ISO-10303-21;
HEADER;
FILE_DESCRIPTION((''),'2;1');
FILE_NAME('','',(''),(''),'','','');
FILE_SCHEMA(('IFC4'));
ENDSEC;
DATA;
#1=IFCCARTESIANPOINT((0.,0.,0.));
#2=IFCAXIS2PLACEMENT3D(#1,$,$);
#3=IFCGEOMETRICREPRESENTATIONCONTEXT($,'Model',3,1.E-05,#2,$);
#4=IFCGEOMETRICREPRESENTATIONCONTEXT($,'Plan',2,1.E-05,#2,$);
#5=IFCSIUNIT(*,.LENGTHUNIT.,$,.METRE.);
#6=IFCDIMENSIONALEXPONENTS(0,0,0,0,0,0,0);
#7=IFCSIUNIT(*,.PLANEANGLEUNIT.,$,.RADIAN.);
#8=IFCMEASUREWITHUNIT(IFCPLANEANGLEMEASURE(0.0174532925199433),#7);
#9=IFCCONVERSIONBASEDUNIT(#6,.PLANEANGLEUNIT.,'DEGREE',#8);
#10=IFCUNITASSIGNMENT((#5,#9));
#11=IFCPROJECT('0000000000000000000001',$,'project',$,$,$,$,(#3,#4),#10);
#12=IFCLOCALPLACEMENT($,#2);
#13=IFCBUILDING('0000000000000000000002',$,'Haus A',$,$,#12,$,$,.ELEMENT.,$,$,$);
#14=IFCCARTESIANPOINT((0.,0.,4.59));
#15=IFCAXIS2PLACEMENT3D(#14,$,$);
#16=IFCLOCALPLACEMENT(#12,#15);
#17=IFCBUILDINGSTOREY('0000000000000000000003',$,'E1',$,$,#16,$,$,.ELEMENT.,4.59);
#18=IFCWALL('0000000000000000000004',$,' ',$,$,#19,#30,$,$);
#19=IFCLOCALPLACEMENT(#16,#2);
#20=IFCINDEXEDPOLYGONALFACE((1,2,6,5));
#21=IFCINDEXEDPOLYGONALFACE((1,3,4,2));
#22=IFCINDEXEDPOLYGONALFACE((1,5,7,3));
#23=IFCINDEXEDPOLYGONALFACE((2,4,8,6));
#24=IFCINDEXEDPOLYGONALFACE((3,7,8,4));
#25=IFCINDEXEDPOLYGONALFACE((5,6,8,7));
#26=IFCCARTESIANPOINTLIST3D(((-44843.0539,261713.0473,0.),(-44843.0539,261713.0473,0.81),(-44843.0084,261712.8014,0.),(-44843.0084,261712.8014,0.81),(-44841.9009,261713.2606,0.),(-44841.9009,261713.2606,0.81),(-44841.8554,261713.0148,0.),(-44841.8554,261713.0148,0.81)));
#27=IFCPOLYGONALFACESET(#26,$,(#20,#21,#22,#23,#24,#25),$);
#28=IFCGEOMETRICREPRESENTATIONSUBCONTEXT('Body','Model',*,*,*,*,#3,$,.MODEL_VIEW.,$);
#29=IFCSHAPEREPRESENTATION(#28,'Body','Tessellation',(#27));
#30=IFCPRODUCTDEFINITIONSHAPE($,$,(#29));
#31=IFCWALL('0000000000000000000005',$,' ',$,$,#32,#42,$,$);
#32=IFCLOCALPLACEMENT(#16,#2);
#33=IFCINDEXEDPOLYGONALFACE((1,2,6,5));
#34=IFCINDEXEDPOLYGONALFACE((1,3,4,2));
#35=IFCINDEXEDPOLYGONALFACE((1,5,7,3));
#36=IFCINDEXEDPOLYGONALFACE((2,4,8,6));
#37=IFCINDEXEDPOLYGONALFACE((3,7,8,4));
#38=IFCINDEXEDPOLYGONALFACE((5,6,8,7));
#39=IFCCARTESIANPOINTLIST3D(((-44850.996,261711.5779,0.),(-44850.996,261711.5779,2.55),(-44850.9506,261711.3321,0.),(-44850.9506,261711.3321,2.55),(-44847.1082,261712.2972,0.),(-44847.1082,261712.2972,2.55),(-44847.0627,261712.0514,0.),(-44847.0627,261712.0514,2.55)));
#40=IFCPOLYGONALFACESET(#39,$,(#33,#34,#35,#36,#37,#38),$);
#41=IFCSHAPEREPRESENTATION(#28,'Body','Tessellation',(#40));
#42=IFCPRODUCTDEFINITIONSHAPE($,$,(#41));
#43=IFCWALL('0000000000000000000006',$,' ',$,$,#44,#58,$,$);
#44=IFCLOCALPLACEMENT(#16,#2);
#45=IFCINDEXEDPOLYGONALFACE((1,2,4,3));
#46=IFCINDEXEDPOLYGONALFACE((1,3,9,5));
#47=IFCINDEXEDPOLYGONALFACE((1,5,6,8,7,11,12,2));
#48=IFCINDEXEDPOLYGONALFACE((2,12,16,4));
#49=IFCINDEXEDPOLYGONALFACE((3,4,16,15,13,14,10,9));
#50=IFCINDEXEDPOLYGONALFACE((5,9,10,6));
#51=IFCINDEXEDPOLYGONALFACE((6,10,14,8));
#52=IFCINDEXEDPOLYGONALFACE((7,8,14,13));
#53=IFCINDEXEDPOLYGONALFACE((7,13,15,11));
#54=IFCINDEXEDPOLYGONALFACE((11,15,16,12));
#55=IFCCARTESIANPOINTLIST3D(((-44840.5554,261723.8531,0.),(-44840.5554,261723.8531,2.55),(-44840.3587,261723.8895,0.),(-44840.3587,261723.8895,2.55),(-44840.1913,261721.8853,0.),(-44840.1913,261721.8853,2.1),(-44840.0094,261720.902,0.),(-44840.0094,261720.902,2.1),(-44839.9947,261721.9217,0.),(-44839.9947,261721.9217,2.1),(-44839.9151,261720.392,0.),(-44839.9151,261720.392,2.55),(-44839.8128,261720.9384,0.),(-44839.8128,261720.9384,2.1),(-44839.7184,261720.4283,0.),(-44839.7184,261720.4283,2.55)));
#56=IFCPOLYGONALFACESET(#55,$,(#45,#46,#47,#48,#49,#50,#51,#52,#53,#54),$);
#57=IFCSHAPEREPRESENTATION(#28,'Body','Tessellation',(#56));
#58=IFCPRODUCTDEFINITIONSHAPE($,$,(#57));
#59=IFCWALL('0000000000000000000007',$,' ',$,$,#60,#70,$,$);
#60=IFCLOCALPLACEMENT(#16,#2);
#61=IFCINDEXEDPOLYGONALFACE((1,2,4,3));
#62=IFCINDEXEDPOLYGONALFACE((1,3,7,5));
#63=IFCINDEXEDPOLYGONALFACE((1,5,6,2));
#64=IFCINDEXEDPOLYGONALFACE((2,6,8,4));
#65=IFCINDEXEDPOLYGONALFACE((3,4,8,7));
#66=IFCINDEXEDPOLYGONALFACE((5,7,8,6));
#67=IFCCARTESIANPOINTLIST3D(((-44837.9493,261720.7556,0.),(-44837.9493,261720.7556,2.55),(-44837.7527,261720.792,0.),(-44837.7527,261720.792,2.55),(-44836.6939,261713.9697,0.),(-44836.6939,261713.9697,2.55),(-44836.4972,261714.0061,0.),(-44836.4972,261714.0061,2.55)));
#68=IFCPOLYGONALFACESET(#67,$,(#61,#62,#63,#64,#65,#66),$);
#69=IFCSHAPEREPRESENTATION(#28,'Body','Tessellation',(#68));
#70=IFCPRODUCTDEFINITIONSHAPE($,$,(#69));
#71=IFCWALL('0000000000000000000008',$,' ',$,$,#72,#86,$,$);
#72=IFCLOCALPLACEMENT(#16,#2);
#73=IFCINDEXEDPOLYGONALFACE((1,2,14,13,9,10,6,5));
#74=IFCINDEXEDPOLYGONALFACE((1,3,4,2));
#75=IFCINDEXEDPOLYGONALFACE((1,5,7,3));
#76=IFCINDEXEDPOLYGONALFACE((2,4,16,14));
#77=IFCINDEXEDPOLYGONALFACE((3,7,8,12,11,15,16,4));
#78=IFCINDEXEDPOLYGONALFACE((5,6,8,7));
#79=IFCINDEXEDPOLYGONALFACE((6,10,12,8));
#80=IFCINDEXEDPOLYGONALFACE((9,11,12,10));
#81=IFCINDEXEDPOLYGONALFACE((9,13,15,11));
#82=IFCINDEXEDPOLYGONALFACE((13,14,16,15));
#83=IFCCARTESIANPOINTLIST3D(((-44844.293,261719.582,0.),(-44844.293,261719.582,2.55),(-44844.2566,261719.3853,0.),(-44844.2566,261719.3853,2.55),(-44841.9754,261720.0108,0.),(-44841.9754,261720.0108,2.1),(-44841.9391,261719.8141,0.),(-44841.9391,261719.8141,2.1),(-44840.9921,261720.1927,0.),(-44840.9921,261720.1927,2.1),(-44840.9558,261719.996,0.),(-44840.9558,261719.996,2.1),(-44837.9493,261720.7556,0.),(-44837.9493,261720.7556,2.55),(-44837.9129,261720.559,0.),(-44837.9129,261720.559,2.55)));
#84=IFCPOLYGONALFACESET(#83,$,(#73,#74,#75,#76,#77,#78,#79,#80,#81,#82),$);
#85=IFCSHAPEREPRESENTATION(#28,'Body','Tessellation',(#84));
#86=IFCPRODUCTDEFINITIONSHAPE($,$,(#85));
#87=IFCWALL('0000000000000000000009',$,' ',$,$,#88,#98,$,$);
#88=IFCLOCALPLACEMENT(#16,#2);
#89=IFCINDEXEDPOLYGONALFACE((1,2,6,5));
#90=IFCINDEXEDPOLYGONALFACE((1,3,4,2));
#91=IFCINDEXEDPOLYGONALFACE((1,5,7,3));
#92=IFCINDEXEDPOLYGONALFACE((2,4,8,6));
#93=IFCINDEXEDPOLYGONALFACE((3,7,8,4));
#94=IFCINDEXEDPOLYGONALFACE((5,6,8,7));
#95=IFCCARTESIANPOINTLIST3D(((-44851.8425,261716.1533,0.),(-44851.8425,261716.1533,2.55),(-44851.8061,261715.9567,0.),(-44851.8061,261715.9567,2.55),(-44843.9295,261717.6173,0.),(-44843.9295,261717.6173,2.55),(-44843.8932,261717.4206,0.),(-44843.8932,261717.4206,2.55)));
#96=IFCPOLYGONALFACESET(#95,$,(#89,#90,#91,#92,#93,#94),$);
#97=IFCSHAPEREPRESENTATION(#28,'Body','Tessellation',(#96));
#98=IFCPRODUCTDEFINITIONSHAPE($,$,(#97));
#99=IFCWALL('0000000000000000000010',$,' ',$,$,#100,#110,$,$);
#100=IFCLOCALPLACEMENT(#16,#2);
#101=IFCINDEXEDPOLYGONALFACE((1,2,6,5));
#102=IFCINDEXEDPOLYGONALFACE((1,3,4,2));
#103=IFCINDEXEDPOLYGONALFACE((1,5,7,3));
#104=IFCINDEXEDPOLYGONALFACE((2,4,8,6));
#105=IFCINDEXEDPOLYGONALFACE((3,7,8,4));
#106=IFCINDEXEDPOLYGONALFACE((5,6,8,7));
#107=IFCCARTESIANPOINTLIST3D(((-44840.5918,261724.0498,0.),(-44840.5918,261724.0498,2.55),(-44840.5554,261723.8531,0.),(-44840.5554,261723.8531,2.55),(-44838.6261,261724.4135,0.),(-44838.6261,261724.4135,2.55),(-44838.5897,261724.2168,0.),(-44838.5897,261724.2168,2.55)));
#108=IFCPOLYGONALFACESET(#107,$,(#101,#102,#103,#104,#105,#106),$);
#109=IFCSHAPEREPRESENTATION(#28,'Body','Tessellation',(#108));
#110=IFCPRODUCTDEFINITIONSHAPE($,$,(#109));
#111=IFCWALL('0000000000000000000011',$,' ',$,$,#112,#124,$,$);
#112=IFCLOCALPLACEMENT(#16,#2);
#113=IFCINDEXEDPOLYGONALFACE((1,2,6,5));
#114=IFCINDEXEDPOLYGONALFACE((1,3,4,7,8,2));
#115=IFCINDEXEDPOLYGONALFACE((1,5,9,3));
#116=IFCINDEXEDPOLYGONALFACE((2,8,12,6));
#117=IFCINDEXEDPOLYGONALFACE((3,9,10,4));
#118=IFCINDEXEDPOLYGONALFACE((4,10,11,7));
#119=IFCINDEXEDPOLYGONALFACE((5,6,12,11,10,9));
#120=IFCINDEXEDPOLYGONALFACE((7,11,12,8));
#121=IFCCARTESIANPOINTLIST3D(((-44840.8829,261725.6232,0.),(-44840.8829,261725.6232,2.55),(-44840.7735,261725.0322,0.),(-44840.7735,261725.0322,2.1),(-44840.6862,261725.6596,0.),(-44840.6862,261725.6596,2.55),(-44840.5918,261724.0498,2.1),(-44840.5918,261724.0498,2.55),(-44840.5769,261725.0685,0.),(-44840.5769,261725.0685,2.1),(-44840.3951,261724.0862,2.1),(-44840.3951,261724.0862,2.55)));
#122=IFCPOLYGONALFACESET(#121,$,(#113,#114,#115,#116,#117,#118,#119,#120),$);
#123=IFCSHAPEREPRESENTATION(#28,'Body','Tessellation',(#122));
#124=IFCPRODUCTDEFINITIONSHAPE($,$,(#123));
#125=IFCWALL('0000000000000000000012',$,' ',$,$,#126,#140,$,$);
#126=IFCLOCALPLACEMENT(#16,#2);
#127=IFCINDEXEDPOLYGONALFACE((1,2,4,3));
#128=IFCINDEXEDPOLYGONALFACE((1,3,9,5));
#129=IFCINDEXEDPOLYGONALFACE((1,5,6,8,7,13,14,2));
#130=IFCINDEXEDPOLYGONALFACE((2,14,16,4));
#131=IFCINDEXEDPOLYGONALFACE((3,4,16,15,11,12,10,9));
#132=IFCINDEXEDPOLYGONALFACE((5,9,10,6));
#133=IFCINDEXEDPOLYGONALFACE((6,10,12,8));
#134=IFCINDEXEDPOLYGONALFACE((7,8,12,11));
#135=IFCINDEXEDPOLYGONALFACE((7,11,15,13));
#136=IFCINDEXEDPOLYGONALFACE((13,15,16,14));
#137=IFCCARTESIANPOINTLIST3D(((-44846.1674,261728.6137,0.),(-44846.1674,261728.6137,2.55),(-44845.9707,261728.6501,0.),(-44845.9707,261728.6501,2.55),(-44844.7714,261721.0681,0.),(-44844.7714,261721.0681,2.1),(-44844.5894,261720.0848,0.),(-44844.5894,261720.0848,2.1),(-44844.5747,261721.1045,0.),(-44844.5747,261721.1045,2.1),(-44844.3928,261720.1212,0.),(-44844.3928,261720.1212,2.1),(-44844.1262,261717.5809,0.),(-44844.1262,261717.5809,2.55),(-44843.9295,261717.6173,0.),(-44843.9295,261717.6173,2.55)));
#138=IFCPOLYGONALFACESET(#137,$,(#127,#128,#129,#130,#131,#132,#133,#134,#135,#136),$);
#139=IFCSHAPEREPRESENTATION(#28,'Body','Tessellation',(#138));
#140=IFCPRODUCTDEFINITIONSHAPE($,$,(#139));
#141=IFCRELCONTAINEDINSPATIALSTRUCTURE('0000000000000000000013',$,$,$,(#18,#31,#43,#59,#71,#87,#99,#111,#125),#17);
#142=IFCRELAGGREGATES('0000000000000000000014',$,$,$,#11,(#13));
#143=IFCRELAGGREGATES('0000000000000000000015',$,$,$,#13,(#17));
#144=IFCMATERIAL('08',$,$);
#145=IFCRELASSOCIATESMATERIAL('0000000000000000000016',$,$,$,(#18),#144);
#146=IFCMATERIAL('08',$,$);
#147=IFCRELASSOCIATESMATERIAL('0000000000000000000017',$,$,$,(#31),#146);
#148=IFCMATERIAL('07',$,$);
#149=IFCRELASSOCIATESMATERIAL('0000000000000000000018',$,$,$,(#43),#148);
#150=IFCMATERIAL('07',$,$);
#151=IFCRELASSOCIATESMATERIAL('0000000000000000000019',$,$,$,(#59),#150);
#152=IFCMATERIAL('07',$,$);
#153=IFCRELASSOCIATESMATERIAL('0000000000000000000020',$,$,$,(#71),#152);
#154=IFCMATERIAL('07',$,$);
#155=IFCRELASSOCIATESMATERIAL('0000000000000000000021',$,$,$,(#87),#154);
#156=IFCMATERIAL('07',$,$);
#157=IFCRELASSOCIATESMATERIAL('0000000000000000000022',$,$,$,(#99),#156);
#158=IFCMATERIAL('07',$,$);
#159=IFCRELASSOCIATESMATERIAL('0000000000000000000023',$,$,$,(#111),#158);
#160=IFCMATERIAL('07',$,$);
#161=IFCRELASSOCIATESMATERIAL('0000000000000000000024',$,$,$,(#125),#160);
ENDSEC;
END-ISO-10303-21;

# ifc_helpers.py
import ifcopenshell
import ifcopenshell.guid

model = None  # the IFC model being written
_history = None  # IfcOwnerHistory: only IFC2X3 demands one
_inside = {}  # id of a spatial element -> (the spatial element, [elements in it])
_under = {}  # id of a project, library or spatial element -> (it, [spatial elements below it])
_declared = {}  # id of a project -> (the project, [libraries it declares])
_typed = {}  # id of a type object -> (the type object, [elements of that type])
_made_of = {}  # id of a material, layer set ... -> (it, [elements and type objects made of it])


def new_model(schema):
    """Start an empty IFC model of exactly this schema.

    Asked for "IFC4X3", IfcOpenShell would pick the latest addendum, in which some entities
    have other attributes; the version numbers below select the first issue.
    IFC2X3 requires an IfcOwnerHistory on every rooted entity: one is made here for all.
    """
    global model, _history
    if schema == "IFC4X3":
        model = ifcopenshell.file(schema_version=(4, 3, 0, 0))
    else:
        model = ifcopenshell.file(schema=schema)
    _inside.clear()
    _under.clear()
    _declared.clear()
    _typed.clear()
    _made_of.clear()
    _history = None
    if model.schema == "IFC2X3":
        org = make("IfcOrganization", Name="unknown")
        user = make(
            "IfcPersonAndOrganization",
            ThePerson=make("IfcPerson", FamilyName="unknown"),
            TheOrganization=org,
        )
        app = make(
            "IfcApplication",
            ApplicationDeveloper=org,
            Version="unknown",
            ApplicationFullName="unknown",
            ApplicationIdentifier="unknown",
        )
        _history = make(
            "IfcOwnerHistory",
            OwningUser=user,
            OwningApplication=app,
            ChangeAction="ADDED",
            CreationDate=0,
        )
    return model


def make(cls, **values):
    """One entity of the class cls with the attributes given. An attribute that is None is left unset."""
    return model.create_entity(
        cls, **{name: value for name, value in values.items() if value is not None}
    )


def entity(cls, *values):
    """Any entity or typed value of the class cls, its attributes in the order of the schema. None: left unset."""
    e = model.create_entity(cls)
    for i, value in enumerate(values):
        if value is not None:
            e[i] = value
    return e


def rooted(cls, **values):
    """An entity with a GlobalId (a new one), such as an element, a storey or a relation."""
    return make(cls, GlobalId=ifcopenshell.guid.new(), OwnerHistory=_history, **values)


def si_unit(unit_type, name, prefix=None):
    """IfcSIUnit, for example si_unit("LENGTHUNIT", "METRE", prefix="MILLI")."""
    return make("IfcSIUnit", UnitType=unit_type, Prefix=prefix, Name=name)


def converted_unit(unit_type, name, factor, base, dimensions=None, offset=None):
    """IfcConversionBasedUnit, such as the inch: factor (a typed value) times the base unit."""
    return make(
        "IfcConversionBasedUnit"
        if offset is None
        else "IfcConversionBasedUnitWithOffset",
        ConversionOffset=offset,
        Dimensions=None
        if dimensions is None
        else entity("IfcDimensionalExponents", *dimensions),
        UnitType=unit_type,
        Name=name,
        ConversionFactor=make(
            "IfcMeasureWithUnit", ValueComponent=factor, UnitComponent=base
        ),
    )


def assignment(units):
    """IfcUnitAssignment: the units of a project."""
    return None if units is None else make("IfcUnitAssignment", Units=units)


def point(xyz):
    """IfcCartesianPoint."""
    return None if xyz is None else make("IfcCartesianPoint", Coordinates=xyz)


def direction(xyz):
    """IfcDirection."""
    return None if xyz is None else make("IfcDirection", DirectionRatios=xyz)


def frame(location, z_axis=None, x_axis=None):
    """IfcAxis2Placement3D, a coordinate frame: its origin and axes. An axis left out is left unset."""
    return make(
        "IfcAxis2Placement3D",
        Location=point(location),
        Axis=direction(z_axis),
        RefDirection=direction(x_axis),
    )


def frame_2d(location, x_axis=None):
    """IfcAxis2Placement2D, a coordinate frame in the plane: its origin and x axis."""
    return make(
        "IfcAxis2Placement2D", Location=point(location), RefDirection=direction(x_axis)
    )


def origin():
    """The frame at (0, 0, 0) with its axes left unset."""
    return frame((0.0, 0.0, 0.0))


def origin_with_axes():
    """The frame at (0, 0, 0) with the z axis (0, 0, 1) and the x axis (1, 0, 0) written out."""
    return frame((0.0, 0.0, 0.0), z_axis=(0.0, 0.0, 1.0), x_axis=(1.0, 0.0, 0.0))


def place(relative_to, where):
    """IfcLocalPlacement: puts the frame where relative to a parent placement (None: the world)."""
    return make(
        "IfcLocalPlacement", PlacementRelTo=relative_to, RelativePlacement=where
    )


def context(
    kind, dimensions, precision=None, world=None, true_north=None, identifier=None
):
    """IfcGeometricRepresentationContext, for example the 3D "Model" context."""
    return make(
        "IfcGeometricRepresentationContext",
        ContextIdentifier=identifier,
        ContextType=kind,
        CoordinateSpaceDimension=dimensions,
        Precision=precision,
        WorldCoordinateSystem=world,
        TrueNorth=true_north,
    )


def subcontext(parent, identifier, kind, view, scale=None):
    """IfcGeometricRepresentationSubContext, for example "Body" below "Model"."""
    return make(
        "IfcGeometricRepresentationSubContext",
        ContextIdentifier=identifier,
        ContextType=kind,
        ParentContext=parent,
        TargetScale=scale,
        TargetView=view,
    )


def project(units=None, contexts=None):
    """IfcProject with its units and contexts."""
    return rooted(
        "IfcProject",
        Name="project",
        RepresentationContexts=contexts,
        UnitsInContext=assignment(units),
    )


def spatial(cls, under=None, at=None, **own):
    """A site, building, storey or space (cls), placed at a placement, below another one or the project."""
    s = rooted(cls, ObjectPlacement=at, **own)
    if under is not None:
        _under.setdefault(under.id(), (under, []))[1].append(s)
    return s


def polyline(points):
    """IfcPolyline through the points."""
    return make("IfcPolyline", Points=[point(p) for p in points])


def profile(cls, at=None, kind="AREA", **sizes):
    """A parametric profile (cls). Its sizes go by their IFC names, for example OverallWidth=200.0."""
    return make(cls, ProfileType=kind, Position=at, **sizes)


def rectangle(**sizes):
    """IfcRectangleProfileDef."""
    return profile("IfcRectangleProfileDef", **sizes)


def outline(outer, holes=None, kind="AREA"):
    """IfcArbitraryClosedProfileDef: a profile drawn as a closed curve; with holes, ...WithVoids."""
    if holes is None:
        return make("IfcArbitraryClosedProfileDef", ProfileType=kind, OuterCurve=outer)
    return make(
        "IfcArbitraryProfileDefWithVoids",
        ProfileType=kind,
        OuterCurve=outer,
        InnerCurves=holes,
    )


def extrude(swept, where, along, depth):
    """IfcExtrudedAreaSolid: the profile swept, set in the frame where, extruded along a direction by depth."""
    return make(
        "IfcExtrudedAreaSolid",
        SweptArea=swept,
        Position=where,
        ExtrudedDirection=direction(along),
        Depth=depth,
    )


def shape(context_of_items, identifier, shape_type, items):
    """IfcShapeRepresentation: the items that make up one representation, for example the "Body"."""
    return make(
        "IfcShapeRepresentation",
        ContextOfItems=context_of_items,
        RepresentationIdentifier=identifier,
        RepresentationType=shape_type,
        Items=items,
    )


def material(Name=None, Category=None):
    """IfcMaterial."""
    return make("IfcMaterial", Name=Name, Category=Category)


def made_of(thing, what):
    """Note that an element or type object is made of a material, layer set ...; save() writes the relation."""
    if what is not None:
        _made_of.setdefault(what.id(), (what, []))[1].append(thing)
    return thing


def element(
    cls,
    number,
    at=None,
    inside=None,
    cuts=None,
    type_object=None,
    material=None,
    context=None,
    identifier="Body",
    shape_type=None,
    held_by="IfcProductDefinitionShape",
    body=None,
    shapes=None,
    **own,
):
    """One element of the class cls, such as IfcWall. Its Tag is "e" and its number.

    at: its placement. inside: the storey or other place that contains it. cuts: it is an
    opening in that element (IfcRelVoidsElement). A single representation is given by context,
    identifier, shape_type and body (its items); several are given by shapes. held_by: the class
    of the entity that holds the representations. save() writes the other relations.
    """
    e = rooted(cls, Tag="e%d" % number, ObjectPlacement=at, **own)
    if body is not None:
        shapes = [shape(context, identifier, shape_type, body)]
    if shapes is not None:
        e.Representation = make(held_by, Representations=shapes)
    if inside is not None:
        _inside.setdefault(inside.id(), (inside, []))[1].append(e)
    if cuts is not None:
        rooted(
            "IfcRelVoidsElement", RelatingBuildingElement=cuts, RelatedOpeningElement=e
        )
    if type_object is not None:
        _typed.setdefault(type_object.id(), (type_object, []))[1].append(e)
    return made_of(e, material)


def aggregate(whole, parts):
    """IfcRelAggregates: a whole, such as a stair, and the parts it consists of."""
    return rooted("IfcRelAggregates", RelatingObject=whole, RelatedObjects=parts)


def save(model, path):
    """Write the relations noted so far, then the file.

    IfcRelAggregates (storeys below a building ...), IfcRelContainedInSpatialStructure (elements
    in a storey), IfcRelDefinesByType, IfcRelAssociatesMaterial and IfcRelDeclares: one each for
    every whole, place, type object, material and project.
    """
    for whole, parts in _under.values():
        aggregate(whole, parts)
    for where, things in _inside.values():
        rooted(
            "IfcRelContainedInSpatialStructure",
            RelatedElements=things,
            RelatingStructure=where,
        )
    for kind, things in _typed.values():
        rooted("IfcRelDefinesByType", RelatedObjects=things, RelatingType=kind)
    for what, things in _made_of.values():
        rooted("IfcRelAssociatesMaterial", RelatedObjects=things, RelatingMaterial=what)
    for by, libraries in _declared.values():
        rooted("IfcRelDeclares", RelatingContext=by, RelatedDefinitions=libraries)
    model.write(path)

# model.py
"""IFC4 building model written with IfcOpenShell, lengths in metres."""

from ifc_helpers import new_model, entity, si_unit, converted_unit, frame, frame_2d, origin, origin_with_axes, place, context, subcontext, project, spatial, polyline, rectangle, outline, extrude, material, element, save


model = new_model("IFC4")

# Units and contexts
model_context = context("Model", 3, precision=1e-05, world=origin())
plan_context = context("Plan", 2, precision=1e-05, world=origin())
body_context = subcontext(model_context, "Body", "Model", "MODEL_VIEW")
ifc_project = project(units=[si_unit("LENGTHUNIT", "METRE"), converted_unit("PLANEANGLEUNIT", "DEGREE", entity("IfcPlaneAngleMeasure", 0.0174532925199433), si_unit("PLANEANGLEUNIT", "RADIAN"), dimensions=[0, 0, 0, 0, 0, 0, 0])], contexts=[model_context, plan_context])

# Building, storey
building_placement = place(None, origin())
building = spatial("IfcBuilding", under=ifc_project, at=building_placement, Name="Haus A", CompositionType="ELEMENT")
storey_placement = place(building_placement, frame((0.0, 0.0, 4.59)))
storey = spatial("IfcBuildingStorey", under=building, at=storey_placement, Name="E1", CompositionType="ELEMENT", Elevation=4.59)

# Walls
ifc_material_1 = material(Name="08")
wall_1_placement = place(storey_placement, frame((-44841.9009, 261713.2606, 0.0), z_axis=(0.0, 0.0, 1.0), x_axis=(-0.983313, -0.18192, 0.0)))
element("IfcWall", 1, at=wall_1_placement, inside=storey, material=ifc_material_1, Name=" ", context=body_context, shape_type="SweptSolid", body=[
    extrude(rectangle(XDim=1.1726, YDim=0.25, at=frame_2d((0.5863, 0.125), x_axis=(1.0, 0.0))), origin_with_axes(), (0.0, 0.0, 1.0), 0.81),
])
ifc_material_2 = material(Name="08")
wall_2_placement = place(storey_placement, frame((-44850.9506, 261711.3321, 0.0), z_axis=(0.0, 0.0, 1.0), x_axis=(0.983313, 0.18192, 0.0)))
element("IfcWall", 2, at=wall_2_placement, inside=storey, material=ifc_material_2, Name=" ", context=body_context, shape_type="SweptSolid", body=[
    extrude(rectangle(XDim=3.9538, YDim=0.25, at=frame_2d((1.9769, 0.125), x_axis=(1.0, 0.0))), origin_with_axes(), (0.0, 0.0, 1.0), 2.55),
])

# Wall, opening
ifc_material_3 = material(Name="07")
wall_3_placement = place(storey_placement, frame((-44839.7184, 261720.4283, 0.0), z_axis=(0.0, 0.0, 1.0), x_axis=(-0.18192, 0.983313, 0.0)))
wall_3 = element("IfcWall", 3, at=wall_3_placement, inside=storey, material=ifc_material_3, Name=" ", context=body_context, shape_type="SweptSolid", body=[
    extrude(rectangle(XDim=3.5199, YDim=0.2, at=frame_2d((1.76, 0.1), x_axis=(1.0, 0.0))), origin_with_axes(), (0.0, 0.0, 1.0), 2.55),
])
opening_1_placement = place(wall_3_placement, frame((0.5187, 0.0, 0.0), z_axis=(0.0, 1.0, 0.0), x_axis=(0.0, 0.0, 1.0)))
element("IfcOpeningElement", 4, at=opening_1_placement, cuts=wall_3, ObjectType="Opening", context=body_context, shape_type="SweptSolid", body=[
    extrude(outline(polyline([(0.0, 1.0), (2.1, 1.0), (2.1, 0.0), (0.0, 0.0), (0.0, 1.0)])), origin_with_axes(), (0.0, 0.0, 1.0), 0.2),
])

# Wall
ifc_material_4 = material(Name="07")
wall_4_placement = place(storey_placement, frame((-44837.9493, 261720.7556, 0.0), z_axis=(0.0, 0.0, 1.0), x_axis=(0.18192, -0.983313, 0.0)))
element("IfcWall", 5, at=wall_4_placement, inside=storey, material=ifc_material_4, Name=" ", context=body_context, shape_type="SweptSolid", body=[
    extrude(rectangle(XDim=6.9011, YDim=0.2, at=frame_2d((3.4506, 0.1), x_axis=(1.0, 0.0))), origin_with_axes(), (0.0, 0.0, 1.0), 2.55),
])

# Wall, opening
ifc_material_5 = material(Name="07")
wall_5_placement = place(storey_placement, frame((-44844.2566, 261719.3853, 0.0), z_axis=(0.0, 0.0, 1.0), x_axis=(0.983313, 0.18192, 0.0)))
wall_5 = element("IfcWall", 6, at=wall_5_placement, inside=storey, material=ifc_material_5, Name=" ", context=body_context, shape_type="SweptSolid", body=[
    extrude(rectangle(XDim=6.4514, YDim=0.2, at=frame_2d((3.2257, 0.1), x_axis=(1.0, 0.0))), origin_with_axes(), (0.0, 0.0, 1.0), 2.55),
])
opening_2_placement = place(wall_5_placement, frame((2.3569, 0.0, 0.0), z_axis=(0.0, 1.0, 0.0), x_axis=(0.0, 0.0, 1.0)))
element("IfcOpeningElement", 7, at=opening_2_placement, cuts=wall_5, ObjectType="Opening", context=body_context, shape_type="SweptSolid", body=[
    extrude(outline(polyline([(0.0, 1.0), (2.1, 1.0), (2.1, 0.0), (0.0, 0.0), (0.0, 1.0)])), origin_with_axes(), (0.0, 0.0, 1.0), 0.2),
])

# Walls
ifc_material_6 = material(Name="07")
wall_6_placement = place(storey_placement, frame((-44851.8061, 261715.9567, 0.0), z_axis=(0.0, 0.0, 1.0), x_axis=(0.983313, 0.18192, 0.0)))
element("IfcWall", 8, at=wall_6_placement, inside=storey, material=ifc_material_6, Name=" ", context=body_context, shape_type="SweptSolid", body=[
    extrude(rectangle(XDim=8.0473, YDim=0.2, at=frame_2d((4.0236, 0.1), x_axis=(1.0, 0.0))), origin_with_axes(), (0.0, 0.0, 1.0), 2.55),
])
ifc_material_7 = material(Name="07")
wall_7_placement = place(storey_placement, frame((-44838.6261, 261724.4135, 0.0), z_axis=(0.0, 0.0, 1.0), x_axis=(-0.983313, -0.18192, 0.0)))
element("IfcWall", 9, at=wall_7_placement, inside=storey, material=ifc_material_7, Name=" ", context=body_context, shape_type="SweptSolid", body=[
    extrude(rectangle(XDim=1.9991, YDim=0.2, at=frame_2d((0.9995, 0.1), x_axis=(1.0, 0.0))), origin_with_axes(), (0.0, 0.0, 1.0), 2.55),
])

# Walls, openings
ifc_material_8 = material(Name="07")
wall_8_placement = place(storey_placement, frame((-44840.3951, 261724.0862, 0.0), z_axis=(0.0, 0.0, 1.0), x_axis=(-0.18192, 0.983313, 0.0)))
wall_8 = element("IfcWall", 10, at=wall_8_placement, inside=storey, material=ifc_material_8, Name=" ", context=body_context, shape_type="SweptSolid", body=[
    extrude(rectangle(XDim=1.6001, YDim=0.2, at=frame_2d((0.8001, 0.1), x_axis=(1.0, 0.0))), origin_with_axes(), (0.0, 0.0, 1.0), 2.55),
])
opening_3_placement = place(wall_8_placement, frame((0.0, 0.0, 0.0), z_axis=(0.0, 1.0, 0.0), x_axis=(0.0, 0.0, 1.0)))
element("IfcOpeningElement", 11, at=opening_3_placement, cuts=wall_8, ObjectType="Opening", context=body_context, shape_type="SweptSolid", body=[
    extrude(outline(polyline([(0.0, 0.999), (2.1, 0.999), (2.1, 0.0), (0.0, 0.0), (0.0, 0.999)])), origin_with_axes(), (0.0, 0.0, 1.0), 0.2),
])
ifc_material_9 = material(Name="07")
wall_9_placement = place(storey_placement, frame((-44843.9295, 261717.6173, 0.0), z_axis=(0.0, 0.0, 1.0), x_axis=(-0.18192, 0.983313, 0.0)))
wall_9 = element("IfcWall", 12, at=wall_9_placement, inside=storey, material=ifc_material_9, Name=" ", context=body_context, shape_type="SweptSolid", body=[
    extrude(rectangle(XDim=11.2201, YDim=0.2, at=frame_2d((5.61, 0.1), x_axis=(1.0, 0.0))), origin_with_axes(), (0.0, 0.0, 1.0), 2.55),
])
opening_4_placement = place(wall_9_placement, frame((2.5464, 0.0, 0.0), z_axis=(0.0, 1.0, 0.0), x_axis=(0.0, 0.0, 1.0)))
element("IfcOpeningElement", 13, at=opening_4_placement, cuts=wall_9, ObjectType="Opening", context=body_context, shape_type="SweptSolid", body=[
    extrude(outline(polyline([(0.0, 1.0), (2.1, 1.0), (2.1, 0.0), (0.0, 0.0), (0.0, 1.0)])), origin_with_axes(), (0.0, 0.0, 1.0), 0.2),
])

save(model, "model.ifc")
